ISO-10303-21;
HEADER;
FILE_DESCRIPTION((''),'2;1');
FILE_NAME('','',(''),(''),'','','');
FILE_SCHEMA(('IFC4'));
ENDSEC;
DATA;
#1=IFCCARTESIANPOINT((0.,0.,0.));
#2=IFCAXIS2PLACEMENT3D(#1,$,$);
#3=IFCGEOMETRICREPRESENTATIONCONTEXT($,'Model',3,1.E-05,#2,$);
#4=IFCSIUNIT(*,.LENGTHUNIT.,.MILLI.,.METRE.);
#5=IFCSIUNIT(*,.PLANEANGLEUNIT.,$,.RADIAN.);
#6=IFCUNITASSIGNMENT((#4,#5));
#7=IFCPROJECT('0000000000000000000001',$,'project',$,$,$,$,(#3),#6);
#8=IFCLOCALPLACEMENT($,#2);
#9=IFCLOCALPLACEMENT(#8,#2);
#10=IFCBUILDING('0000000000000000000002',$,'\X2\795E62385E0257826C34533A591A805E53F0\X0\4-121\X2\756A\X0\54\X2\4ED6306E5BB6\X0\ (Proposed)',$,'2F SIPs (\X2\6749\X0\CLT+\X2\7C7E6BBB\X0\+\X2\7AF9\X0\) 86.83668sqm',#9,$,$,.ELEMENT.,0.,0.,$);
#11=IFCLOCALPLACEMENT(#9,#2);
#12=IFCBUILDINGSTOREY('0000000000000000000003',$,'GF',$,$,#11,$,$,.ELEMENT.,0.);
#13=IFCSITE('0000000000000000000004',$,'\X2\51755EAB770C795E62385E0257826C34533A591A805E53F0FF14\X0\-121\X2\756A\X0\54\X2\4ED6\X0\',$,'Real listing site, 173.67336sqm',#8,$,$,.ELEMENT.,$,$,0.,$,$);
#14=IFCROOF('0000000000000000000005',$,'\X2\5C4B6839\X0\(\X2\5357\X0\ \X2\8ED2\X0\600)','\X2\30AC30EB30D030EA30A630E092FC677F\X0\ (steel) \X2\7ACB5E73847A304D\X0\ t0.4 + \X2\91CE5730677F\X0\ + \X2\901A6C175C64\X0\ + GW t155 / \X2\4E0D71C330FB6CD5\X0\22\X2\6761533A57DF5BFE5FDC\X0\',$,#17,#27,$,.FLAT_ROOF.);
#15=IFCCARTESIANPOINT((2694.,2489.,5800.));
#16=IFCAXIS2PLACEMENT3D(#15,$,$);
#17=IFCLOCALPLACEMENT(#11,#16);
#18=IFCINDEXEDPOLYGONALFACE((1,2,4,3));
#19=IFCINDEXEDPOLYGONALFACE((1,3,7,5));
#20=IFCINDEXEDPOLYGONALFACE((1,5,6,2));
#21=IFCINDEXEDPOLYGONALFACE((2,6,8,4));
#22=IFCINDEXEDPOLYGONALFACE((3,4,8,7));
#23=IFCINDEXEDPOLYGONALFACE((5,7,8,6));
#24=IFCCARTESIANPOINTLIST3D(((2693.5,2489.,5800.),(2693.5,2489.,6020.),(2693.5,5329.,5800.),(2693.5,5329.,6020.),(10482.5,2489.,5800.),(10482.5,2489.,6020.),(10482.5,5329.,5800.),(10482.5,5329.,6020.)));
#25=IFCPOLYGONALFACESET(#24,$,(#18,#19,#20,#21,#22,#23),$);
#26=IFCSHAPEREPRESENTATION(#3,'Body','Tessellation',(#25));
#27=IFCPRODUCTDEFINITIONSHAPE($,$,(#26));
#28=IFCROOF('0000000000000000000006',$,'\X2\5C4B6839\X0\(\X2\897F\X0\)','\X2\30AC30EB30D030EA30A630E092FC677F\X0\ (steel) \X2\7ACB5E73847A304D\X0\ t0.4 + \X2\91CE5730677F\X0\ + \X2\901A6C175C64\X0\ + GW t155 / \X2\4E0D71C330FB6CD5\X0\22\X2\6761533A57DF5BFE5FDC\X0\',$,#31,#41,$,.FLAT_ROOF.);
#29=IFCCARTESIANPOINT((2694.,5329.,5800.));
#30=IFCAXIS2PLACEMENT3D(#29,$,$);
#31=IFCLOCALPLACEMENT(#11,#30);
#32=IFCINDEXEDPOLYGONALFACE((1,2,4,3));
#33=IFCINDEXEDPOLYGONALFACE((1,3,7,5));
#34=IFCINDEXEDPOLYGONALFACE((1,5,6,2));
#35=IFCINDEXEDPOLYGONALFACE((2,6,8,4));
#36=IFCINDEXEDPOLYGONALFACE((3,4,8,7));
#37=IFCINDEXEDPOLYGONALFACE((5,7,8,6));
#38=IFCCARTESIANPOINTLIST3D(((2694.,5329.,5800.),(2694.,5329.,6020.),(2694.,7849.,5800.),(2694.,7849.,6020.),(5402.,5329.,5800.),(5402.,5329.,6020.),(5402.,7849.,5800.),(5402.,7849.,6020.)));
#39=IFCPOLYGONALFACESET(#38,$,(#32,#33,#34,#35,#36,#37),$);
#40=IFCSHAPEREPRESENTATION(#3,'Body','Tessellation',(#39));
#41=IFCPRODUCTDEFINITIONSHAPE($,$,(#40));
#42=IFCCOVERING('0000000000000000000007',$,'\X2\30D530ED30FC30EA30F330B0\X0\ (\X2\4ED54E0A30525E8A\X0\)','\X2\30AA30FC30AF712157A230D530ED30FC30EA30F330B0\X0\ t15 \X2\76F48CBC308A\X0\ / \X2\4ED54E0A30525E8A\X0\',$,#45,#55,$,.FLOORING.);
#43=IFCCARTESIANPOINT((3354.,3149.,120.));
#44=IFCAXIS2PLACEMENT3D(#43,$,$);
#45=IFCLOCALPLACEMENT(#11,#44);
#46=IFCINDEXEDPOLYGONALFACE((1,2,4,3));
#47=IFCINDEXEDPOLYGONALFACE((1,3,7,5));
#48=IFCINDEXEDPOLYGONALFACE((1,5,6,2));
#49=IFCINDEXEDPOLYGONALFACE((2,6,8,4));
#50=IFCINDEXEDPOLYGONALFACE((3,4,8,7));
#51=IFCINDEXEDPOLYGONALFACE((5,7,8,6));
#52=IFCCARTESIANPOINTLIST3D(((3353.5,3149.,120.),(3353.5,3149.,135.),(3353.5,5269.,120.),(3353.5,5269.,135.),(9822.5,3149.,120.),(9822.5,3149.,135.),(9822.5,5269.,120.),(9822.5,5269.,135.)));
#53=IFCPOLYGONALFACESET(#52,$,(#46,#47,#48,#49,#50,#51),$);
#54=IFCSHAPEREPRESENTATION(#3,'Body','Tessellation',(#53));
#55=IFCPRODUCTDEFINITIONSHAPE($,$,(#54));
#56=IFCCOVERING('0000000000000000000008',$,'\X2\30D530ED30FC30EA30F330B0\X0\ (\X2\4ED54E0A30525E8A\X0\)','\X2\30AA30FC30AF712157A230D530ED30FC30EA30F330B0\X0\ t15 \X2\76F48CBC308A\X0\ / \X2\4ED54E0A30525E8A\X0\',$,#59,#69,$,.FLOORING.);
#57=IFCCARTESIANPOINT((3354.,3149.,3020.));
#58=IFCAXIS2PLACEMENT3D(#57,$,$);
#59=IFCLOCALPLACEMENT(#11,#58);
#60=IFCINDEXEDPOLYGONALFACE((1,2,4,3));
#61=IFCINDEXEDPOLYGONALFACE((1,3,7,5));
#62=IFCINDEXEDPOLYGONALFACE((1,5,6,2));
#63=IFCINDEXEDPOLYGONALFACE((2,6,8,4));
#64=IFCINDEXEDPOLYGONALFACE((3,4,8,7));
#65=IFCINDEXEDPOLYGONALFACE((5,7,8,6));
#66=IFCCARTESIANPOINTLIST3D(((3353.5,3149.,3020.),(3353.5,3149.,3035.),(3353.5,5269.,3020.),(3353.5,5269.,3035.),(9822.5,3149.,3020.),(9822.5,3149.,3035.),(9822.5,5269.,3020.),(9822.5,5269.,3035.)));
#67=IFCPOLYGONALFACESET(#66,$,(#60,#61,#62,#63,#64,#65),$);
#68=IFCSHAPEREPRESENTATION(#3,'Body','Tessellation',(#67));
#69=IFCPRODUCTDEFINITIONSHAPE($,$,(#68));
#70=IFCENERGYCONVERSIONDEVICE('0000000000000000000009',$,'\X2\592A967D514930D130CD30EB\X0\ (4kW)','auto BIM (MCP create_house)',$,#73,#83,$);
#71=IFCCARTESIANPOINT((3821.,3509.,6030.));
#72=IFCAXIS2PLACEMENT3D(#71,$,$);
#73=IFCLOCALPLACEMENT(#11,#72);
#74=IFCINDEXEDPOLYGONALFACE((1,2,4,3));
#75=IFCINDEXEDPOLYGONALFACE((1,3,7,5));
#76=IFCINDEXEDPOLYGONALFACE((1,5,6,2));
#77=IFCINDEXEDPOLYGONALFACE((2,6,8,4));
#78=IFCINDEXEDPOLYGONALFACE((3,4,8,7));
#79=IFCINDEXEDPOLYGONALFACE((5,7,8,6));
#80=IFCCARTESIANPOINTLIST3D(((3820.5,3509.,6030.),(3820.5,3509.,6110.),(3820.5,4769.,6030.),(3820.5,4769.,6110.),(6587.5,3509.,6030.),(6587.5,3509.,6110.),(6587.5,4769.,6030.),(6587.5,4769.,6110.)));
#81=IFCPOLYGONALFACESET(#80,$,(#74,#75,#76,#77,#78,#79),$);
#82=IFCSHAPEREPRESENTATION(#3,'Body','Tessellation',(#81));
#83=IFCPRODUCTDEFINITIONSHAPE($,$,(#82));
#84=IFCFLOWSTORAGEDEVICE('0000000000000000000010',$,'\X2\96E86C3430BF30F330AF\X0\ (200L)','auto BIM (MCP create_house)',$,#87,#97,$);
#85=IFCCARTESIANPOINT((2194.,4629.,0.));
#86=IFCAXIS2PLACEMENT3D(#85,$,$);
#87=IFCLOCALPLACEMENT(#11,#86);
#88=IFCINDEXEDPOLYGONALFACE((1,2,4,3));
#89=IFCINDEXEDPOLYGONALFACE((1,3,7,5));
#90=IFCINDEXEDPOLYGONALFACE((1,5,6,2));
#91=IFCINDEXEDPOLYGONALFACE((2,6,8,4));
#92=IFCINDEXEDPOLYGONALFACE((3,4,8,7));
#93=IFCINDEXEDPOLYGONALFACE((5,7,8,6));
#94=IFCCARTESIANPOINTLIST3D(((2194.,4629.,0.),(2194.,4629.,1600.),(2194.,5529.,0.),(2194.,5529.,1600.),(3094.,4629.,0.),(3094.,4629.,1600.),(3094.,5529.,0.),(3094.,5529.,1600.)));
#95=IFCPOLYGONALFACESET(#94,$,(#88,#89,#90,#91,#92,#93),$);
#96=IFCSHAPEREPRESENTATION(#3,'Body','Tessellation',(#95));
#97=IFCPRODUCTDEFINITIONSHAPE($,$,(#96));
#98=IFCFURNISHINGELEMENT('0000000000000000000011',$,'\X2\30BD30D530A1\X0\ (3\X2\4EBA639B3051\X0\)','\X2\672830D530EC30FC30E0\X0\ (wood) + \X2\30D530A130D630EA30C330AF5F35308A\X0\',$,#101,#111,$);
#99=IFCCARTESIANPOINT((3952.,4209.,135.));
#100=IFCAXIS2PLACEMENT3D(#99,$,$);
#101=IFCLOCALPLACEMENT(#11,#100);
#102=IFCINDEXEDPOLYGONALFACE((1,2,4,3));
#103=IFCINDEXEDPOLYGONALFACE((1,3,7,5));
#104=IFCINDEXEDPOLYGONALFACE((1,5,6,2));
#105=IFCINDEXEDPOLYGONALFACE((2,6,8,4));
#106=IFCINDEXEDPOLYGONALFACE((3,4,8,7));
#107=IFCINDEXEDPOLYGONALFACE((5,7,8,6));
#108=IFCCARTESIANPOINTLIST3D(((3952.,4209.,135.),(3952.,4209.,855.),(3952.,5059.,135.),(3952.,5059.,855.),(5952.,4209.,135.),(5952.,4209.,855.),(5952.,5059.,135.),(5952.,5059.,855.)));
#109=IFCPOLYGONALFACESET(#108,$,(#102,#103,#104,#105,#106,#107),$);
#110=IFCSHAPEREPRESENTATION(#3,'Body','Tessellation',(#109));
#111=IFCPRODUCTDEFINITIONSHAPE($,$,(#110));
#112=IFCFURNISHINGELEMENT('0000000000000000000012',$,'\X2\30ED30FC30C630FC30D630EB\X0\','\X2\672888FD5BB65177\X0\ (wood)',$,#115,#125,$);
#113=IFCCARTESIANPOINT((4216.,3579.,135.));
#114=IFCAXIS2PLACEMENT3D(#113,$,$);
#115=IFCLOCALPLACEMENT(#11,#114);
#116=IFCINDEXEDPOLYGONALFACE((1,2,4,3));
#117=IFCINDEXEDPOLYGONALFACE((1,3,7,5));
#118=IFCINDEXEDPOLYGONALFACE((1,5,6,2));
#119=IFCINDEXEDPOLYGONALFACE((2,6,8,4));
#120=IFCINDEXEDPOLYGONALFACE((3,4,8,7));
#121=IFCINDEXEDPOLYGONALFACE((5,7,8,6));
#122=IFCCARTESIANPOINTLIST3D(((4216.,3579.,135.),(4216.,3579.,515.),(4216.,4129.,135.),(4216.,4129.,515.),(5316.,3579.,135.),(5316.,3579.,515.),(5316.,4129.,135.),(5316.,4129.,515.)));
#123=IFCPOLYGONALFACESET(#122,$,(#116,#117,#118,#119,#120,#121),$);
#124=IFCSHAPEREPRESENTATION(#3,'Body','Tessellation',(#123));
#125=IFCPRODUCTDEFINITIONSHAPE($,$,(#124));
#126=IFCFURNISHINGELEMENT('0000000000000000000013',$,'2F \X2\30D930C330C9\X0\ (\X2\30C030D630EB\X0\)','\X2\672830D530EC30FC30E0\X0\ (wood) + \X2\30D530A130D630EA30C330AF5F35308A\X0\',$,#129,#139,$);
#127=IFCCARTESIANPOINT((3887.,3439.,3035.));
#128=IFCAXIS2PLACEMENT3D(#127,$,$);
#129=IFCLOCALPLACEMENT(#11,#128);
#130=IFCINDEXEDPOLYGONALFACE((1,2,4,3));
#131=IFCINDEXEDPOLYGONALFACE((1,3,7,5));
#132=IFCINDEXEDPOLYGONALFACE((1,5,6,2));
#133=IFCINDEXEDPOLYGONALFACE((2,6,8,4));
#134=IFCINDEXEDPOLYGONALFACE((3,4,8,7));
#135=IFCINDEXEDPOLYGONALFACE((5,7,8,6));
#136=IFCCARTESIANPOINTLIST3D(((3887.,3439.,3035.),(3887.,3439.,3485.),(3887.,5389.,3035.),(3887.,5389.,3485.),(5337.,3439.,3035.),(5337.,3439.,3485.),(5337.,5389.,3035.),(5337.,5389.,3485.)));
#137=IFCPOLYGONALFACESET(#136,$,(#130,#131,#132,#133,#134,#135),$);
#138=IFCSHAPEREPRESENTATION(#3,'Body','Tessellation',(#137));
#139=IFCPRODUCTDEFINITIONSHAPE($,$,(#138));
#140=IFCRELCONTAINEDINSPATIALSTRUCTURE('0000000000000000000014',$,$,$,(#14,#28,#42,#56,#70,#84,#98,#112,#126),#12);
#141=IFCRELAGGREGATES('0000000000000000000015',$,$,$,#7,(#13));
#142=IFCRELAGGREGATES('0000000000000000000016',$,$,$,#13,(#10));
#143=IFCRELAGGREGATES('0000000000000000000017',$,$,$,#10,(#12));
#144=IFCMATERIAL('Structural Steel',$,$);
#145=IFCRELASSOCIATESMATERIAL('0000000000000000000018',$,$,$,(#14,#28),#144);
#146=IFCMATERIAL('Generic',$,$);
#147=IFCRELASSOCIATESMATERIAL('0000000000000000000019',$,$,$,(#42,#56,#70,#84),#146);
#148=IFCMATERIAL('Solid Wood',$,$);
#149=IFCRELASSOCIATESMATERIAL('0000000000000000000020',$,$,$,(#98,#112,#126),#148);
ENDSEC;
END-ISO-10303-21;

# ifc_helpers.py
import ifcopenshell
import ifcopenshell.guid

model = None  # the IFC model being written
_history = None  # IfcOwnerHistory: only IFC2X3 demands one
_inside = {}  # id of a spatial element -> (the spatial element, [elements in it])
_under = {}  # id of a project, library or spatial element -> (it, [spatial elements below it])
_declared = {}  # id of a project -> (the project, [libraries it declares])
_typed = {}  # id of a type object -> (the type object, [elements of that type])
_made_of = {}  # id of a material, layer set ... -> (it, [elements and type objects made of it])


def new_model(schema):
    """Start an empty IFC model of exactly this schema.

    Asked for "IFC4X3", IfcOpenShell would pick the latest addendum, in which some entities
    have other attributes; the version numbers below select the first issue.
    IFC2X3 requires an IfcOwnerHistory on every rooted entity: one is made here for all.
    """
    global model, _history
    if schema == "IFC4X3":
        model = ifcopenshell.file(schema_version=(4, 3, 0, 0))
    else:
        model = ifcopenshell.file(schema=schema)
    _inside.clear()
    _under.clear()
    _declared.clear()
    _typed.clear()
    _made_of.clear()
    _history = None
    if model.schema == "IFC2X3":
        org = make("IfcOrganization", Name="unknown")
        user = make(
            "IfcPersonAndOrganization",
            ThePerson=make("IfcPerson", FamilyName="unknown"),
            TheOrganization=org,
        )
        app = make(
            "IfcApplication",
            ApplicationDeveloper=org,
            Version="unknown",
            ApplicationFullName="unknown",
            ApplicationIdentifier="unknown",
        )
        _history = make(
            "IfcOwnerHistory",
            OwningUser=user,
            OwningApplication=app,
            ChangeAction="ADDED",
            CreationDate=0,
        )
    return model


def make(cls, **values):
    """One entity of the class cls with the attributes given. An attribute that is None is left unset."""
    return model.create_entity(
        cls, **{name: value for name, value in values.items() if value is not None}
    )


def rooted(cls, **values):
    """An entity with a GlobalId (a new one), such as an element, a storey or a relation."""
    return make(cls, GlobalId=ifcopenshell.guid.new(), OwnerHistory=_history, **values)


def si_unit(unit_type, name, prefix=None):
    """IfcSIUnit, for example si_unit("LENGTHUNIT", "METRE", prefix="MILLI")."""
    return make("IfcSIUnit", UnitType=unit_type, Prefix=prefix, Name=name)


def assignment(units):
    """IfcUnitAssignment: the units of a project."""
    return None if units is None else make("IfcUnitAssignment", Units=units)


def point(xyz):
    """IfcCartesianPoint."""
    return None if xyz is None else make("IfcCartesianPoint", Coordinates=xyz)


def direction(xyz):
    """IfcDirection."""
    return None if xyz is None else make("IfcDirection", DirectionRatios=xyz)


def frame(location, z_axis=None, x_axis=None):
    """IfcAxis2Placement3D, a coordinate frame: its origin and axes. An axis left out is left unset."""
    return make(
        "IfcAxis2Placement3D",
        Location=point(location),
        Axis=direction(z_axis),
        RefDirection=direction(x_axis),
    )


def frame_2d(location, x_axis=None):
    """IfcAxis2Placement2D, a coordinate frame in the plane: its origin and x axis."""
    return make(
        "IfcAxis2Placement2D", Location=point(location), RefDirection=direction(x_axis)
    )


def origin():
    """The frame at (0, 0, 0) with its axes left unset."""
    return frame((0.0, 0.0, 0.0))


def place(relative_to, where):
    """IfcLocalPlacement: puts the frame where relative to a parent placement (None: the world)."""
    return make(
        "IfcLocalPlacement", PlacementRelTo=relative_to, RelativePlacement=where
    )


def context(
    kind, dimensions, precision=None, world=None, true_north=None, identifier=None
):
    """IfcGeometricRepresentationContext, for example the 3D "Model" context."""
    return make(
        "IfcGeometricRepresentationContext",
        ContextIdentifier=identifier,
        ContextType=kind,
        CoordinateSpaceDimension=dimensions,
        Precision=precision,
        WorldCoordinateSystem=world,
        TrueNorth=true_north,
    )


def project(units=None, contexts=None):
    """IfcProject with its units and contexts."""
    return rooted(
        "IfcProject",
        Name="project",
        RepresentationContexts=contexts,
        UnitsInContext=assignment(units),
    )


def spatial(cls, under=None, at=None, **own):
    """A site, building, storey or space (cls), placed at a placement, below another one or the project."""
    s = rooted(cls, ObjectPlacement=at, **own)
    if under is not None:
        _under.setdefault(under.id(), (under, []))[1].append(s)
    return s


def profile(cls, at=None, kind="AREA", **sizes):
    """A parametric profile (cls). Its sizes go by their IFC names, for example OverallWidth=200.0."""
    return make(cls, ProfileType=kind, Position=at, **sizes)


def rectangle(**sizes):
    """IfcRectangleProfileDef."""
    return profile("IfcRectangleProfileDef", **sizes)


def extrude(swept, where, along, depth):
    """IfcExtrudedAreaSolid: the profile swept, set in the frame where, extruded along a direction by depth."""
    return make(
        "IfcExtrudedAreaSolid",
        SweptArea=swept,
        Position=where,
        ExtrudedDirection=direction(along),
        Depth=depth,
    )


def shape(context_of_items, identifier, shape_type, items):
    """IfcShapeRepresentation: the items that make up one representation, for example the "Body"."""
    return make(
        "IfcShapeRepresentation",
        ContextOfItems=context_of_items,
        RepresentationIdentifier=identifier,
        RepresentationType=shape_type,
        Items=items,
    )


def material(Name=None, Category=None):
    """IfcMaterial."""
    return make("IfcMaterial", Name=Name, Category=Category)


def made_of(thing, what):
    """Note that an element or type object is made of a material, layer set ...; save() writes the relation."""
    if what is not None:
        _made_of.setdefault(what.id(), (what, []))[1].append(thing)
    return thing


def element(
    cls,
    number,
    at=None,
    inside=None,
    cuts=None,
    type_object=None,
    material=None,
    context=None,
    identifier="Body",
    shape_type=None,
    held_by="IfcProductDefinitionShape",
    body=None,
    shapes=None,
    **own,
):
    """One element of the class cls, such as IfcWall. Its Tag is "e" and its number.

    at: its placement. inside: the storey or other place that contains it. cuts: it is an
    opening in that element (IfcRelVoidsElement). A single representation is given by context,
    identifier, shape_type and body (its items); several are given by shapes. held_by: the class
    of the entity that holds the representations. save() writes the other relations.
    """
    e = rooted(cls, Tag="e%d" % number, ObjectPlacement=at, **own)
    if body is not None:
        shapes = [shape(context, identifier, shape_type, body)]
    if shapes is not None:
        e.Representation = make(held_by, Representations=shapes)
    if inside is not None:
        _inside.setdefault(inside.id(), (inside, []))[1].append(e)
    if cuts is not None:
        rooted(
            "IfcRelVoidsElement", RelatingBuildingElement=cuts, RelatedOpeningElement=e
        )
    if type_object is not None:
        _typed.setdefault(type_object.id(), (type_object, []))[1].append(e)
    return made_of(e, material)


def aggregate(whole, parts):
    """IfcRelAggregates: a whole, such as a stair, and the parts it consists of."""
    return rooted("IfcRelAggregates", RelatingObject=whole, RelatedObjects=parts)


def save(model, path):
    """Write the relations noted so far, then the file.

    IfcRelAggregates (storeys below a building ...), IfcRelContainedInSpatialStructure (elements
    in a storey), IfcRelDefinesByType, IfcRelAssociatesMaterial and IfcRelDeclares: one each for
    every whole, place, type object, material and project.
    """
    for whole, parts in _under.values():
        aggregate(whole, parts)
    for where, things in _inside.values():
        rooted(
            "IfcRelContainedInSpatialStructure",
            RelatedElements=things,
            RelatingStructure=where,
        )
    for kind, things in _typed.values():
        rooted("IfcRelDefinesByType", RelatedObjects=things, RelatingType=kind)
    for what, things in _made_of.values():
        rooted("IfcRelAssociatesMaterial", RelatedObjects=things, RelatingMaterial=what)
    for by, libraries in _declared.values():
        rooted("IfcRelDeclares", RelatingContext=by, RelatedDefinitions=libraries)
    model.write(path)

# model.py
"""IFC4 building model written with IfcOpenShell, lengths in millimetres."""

from ifc_helpers import new_model, si_unit, frame, frame_2d, origin, place, context, project, spatial, rectangle, extrude, material, element, save


model = new_model("IFC4")

# Units and contexts
model_context = context("Model", 3, precision=1e-05, world=origin())
ifc_project = project(units=[si_unit("LENGTHUNIT", "METRE", prefix="MILLI"), si_unit("PLANEANGLEUNIT", "RADIAN")], contexts=[model_context])

# Site, building, storey
site_placement = place(None, origin())
site = spatial("IfcSite", under=ifc_project, at=site_placement, Name="兵庫県神戸市垂水区多聞台４-121番54他", ObjectType="Real listing site, 173.67336sqm", CompositionType="ELEMENT", RefElevation=0.0)
building_placement = place(site_placement, origin())
building = spatial("IfcBuilding", under=site, at=building_placement, Name="神戸市垂水区多聞台4-121番54他の家 (Proposed)", ObjectType="2F SIPs (杉CLT+籾殻+竹) 86.83668sqm", CompositionType="ELEMENT", ElevationOfRefHeight=0.0, ElevationOfTerrain=0.0)
storey_placement = place(building_placement, origin())
storey = spatial("IfcBuildingStorey", under=building, at=storey_placement, Name="GF", CompositionType="ELEMENT", Elevation=0.0)

# Shared definitions
ifc_material_1 = material(Name="Solid Wood")

# Roofs
ifc_material_2 = material(Name="Structural Steel")
roof_1_placement = place(storey_placement, frame((2694.0, 2489.0, 5800.0)))
element("IfcRoof", 1, at=roof_1_placement, inside=storey, material=ifc_material_2, Name="屋根(南 軒600)", Description="ガルバリウム鋼板 (steel) 立平葺き t0.4 + 野地板 + 通気層 + GW t155 / 不燃・法22条区域対応", PredefinedType="FLAT_ROOF", context=model_context, shape_type="SweptSolid", body=[
    extrude(rectangle(XDim=7789.0, YDim=2840.0, at=frame_2d((3894.0, 1420.0))), frame((2694.0, 2489.0, 5800.0)), (0.0, 0.0, 1.0), 220.0),
])
roof_2_placement = place(storey_placement, frame((2694.0, 5329.0, 5800.0)))
element("IfcRoof", 2, at=roof_2_placement, inside=storey, material=ifc_material_2, Name="屋根(西)", Description="ガルバリウム鋼板 (steel) 立平葺き t0.4 + 野地板 + 通気層 + GW t155 / 不燃・法22条区域対応", PredefinedType="FLAT_ROOF", context=model_context, shape_type="SweptSolid", body=[
    extrude(rectangle(XDim=2708.0, YDim=2520.0, at=frame_2d((1354.0, 1260.0))), frame((2694.0, 5329.0, 5800.0)), (0.0, 0.0, 1.0), 220.0),
])

# Coverings
ifc_material_3 = material(Name="Generic")
covering_1_placement = place(storey_placement, frame((3354.0, 3149.0, 120.0)))
element("IfcCovering", 3, at=covering_1_placement, inside=storey, material=ifc_material_3, Name="フローリング (仕上げ床)", Description="オーク無垢フローリング t15 直貼り / 仕上げ床", PredefinedType="FLOORING", context=model_context, shape_type="SweptSolid", body=[
    extrude(rectangle(XDim=6469.0, YDim=2120.0, at=frame_2d((3234.0, 1060.0))), frame((3354.0, 3149.0, 120.0)), (0.0, 0.0, 1.0), 15.0),
])
covering_2_placement = place(storey_placement, frame((3354.0, 3149.0, 3020.0)))
element("IfcCovering", 4, at=covering_2_placement, inside=storey, material=ifc_material_3, Name="フローリング (仕上げ床)", Description="オーク無垢フローリング t15 直貼り / 仕上げ床", PredefinedType="FLOORING", context=model_context, shape_type="SweptSolid", body=[
    extrude(rectangle(XDim=6469.0, YDim=2120.0, at=frame_2d((3234.0, 1060.0))), frame((3354.0, 3149.0, 3020.0)), (0.0, 0.0, 1.0), 15.0),
])

# Energy conversion device
energy_conversion_device_placement = place(storey_placement, frame((3821.0, 3509.0, 6030.0)))
element("IfcEnergyConversionDevice", 5, at=energy_conversion_device_placement, inside=storey, material=ifc_material_3, Name="太陽光パネル (4kW)", Description="auto BIM (MCP create_house)", context=model_context, shape_type="SweptSolid", body=[
    extrude(rectangle(XDim=2767.0, YDim=1260.0, at=frame_2d((1383.0, 630.0))), frame((3821.0, 3509.0, 6030.0)), (0.0, 0.0, 1.0), 80.0),
])

# Flow storage device
flow_storage_device_placement = place(storey_placement, frame((2194.0, 4629.0, 0.0)))
element("IfcFlowStorageDevice", 6, at=flow_storage_device_placement, inside=storey, material=ifc_material_3, Name="雨水タンク (200L)", Description="auto BIM (MCP create_house)", context=model_context, shape_type="SweptSolid", body=[
    extrude(rectangle(XDim=900.0, YDim=900.0, at=frame_2d((450.0, 450.0))), frame((2194.0, 4629.0, 0.0)), (0.0, 0.0, 1.0), 1600.0),
])

# Furnishing elements
furnishing_1_placement = place(storey_placement, frame((3952.0, 4209.0, 135.0)))
element("IfcFurnishingElement", 7, at=furnishing_1_placement, inside=storey, material=ifc_material_1, Name="ソファ (3人掛け)", Description="木フレーム (wood) + ファブリック張り", context=model_context, shape_type="SweptSolid", body=[
    extrude(rectangle(XDim=2000.0, YDim=850.0, at=frame_2d((1000.0, 425.0))), frame((3952.0, 4209.0, 135.0)), (0.0, 0.0, 1.0), 720.0),
])
furnishing_2_placement = place(storey_placement, frame((4216.0, 3579.0, 135.0)))
element("IfcFurnishingElement", 8, at=furnishing_2_placement, inside=storey, material=ifc_material_1, Name="ローテーブル", Description="木製家具 (wood)", context=model_context, shape_type="SweptSolid", body=[
    extrude(rectangle(XDim=1100.0, YDim=550.0, at=frame_2d((550.0, 275.0))), frame((4216.0, 3579.0, 135.0)), (0.0, 0.0, 1.0), 380.0),
])
furnishing_3_placement = place(storey_placement, frame((3887.0, 3439.0, 3035.0)))
element("IfcFurnishingElement", 9, at=furnishing_3_placement, inside=storey, material=ifc_material_1, Name="2F ベッド (ダブル)", Description="木フレーム (wood) + ファブリック張り", context=model_context, shape_type="SweptSolid", body=[
    extrude(rectangle(XDim=1450.0, YDim=1950.0, at=frame_2d((725.0, 975.0))), frame((3887.0, 3439.0, 3035.0)), (0.0, 0.0, 1.0), 450.0),
])

save(model, "model.ifc")
